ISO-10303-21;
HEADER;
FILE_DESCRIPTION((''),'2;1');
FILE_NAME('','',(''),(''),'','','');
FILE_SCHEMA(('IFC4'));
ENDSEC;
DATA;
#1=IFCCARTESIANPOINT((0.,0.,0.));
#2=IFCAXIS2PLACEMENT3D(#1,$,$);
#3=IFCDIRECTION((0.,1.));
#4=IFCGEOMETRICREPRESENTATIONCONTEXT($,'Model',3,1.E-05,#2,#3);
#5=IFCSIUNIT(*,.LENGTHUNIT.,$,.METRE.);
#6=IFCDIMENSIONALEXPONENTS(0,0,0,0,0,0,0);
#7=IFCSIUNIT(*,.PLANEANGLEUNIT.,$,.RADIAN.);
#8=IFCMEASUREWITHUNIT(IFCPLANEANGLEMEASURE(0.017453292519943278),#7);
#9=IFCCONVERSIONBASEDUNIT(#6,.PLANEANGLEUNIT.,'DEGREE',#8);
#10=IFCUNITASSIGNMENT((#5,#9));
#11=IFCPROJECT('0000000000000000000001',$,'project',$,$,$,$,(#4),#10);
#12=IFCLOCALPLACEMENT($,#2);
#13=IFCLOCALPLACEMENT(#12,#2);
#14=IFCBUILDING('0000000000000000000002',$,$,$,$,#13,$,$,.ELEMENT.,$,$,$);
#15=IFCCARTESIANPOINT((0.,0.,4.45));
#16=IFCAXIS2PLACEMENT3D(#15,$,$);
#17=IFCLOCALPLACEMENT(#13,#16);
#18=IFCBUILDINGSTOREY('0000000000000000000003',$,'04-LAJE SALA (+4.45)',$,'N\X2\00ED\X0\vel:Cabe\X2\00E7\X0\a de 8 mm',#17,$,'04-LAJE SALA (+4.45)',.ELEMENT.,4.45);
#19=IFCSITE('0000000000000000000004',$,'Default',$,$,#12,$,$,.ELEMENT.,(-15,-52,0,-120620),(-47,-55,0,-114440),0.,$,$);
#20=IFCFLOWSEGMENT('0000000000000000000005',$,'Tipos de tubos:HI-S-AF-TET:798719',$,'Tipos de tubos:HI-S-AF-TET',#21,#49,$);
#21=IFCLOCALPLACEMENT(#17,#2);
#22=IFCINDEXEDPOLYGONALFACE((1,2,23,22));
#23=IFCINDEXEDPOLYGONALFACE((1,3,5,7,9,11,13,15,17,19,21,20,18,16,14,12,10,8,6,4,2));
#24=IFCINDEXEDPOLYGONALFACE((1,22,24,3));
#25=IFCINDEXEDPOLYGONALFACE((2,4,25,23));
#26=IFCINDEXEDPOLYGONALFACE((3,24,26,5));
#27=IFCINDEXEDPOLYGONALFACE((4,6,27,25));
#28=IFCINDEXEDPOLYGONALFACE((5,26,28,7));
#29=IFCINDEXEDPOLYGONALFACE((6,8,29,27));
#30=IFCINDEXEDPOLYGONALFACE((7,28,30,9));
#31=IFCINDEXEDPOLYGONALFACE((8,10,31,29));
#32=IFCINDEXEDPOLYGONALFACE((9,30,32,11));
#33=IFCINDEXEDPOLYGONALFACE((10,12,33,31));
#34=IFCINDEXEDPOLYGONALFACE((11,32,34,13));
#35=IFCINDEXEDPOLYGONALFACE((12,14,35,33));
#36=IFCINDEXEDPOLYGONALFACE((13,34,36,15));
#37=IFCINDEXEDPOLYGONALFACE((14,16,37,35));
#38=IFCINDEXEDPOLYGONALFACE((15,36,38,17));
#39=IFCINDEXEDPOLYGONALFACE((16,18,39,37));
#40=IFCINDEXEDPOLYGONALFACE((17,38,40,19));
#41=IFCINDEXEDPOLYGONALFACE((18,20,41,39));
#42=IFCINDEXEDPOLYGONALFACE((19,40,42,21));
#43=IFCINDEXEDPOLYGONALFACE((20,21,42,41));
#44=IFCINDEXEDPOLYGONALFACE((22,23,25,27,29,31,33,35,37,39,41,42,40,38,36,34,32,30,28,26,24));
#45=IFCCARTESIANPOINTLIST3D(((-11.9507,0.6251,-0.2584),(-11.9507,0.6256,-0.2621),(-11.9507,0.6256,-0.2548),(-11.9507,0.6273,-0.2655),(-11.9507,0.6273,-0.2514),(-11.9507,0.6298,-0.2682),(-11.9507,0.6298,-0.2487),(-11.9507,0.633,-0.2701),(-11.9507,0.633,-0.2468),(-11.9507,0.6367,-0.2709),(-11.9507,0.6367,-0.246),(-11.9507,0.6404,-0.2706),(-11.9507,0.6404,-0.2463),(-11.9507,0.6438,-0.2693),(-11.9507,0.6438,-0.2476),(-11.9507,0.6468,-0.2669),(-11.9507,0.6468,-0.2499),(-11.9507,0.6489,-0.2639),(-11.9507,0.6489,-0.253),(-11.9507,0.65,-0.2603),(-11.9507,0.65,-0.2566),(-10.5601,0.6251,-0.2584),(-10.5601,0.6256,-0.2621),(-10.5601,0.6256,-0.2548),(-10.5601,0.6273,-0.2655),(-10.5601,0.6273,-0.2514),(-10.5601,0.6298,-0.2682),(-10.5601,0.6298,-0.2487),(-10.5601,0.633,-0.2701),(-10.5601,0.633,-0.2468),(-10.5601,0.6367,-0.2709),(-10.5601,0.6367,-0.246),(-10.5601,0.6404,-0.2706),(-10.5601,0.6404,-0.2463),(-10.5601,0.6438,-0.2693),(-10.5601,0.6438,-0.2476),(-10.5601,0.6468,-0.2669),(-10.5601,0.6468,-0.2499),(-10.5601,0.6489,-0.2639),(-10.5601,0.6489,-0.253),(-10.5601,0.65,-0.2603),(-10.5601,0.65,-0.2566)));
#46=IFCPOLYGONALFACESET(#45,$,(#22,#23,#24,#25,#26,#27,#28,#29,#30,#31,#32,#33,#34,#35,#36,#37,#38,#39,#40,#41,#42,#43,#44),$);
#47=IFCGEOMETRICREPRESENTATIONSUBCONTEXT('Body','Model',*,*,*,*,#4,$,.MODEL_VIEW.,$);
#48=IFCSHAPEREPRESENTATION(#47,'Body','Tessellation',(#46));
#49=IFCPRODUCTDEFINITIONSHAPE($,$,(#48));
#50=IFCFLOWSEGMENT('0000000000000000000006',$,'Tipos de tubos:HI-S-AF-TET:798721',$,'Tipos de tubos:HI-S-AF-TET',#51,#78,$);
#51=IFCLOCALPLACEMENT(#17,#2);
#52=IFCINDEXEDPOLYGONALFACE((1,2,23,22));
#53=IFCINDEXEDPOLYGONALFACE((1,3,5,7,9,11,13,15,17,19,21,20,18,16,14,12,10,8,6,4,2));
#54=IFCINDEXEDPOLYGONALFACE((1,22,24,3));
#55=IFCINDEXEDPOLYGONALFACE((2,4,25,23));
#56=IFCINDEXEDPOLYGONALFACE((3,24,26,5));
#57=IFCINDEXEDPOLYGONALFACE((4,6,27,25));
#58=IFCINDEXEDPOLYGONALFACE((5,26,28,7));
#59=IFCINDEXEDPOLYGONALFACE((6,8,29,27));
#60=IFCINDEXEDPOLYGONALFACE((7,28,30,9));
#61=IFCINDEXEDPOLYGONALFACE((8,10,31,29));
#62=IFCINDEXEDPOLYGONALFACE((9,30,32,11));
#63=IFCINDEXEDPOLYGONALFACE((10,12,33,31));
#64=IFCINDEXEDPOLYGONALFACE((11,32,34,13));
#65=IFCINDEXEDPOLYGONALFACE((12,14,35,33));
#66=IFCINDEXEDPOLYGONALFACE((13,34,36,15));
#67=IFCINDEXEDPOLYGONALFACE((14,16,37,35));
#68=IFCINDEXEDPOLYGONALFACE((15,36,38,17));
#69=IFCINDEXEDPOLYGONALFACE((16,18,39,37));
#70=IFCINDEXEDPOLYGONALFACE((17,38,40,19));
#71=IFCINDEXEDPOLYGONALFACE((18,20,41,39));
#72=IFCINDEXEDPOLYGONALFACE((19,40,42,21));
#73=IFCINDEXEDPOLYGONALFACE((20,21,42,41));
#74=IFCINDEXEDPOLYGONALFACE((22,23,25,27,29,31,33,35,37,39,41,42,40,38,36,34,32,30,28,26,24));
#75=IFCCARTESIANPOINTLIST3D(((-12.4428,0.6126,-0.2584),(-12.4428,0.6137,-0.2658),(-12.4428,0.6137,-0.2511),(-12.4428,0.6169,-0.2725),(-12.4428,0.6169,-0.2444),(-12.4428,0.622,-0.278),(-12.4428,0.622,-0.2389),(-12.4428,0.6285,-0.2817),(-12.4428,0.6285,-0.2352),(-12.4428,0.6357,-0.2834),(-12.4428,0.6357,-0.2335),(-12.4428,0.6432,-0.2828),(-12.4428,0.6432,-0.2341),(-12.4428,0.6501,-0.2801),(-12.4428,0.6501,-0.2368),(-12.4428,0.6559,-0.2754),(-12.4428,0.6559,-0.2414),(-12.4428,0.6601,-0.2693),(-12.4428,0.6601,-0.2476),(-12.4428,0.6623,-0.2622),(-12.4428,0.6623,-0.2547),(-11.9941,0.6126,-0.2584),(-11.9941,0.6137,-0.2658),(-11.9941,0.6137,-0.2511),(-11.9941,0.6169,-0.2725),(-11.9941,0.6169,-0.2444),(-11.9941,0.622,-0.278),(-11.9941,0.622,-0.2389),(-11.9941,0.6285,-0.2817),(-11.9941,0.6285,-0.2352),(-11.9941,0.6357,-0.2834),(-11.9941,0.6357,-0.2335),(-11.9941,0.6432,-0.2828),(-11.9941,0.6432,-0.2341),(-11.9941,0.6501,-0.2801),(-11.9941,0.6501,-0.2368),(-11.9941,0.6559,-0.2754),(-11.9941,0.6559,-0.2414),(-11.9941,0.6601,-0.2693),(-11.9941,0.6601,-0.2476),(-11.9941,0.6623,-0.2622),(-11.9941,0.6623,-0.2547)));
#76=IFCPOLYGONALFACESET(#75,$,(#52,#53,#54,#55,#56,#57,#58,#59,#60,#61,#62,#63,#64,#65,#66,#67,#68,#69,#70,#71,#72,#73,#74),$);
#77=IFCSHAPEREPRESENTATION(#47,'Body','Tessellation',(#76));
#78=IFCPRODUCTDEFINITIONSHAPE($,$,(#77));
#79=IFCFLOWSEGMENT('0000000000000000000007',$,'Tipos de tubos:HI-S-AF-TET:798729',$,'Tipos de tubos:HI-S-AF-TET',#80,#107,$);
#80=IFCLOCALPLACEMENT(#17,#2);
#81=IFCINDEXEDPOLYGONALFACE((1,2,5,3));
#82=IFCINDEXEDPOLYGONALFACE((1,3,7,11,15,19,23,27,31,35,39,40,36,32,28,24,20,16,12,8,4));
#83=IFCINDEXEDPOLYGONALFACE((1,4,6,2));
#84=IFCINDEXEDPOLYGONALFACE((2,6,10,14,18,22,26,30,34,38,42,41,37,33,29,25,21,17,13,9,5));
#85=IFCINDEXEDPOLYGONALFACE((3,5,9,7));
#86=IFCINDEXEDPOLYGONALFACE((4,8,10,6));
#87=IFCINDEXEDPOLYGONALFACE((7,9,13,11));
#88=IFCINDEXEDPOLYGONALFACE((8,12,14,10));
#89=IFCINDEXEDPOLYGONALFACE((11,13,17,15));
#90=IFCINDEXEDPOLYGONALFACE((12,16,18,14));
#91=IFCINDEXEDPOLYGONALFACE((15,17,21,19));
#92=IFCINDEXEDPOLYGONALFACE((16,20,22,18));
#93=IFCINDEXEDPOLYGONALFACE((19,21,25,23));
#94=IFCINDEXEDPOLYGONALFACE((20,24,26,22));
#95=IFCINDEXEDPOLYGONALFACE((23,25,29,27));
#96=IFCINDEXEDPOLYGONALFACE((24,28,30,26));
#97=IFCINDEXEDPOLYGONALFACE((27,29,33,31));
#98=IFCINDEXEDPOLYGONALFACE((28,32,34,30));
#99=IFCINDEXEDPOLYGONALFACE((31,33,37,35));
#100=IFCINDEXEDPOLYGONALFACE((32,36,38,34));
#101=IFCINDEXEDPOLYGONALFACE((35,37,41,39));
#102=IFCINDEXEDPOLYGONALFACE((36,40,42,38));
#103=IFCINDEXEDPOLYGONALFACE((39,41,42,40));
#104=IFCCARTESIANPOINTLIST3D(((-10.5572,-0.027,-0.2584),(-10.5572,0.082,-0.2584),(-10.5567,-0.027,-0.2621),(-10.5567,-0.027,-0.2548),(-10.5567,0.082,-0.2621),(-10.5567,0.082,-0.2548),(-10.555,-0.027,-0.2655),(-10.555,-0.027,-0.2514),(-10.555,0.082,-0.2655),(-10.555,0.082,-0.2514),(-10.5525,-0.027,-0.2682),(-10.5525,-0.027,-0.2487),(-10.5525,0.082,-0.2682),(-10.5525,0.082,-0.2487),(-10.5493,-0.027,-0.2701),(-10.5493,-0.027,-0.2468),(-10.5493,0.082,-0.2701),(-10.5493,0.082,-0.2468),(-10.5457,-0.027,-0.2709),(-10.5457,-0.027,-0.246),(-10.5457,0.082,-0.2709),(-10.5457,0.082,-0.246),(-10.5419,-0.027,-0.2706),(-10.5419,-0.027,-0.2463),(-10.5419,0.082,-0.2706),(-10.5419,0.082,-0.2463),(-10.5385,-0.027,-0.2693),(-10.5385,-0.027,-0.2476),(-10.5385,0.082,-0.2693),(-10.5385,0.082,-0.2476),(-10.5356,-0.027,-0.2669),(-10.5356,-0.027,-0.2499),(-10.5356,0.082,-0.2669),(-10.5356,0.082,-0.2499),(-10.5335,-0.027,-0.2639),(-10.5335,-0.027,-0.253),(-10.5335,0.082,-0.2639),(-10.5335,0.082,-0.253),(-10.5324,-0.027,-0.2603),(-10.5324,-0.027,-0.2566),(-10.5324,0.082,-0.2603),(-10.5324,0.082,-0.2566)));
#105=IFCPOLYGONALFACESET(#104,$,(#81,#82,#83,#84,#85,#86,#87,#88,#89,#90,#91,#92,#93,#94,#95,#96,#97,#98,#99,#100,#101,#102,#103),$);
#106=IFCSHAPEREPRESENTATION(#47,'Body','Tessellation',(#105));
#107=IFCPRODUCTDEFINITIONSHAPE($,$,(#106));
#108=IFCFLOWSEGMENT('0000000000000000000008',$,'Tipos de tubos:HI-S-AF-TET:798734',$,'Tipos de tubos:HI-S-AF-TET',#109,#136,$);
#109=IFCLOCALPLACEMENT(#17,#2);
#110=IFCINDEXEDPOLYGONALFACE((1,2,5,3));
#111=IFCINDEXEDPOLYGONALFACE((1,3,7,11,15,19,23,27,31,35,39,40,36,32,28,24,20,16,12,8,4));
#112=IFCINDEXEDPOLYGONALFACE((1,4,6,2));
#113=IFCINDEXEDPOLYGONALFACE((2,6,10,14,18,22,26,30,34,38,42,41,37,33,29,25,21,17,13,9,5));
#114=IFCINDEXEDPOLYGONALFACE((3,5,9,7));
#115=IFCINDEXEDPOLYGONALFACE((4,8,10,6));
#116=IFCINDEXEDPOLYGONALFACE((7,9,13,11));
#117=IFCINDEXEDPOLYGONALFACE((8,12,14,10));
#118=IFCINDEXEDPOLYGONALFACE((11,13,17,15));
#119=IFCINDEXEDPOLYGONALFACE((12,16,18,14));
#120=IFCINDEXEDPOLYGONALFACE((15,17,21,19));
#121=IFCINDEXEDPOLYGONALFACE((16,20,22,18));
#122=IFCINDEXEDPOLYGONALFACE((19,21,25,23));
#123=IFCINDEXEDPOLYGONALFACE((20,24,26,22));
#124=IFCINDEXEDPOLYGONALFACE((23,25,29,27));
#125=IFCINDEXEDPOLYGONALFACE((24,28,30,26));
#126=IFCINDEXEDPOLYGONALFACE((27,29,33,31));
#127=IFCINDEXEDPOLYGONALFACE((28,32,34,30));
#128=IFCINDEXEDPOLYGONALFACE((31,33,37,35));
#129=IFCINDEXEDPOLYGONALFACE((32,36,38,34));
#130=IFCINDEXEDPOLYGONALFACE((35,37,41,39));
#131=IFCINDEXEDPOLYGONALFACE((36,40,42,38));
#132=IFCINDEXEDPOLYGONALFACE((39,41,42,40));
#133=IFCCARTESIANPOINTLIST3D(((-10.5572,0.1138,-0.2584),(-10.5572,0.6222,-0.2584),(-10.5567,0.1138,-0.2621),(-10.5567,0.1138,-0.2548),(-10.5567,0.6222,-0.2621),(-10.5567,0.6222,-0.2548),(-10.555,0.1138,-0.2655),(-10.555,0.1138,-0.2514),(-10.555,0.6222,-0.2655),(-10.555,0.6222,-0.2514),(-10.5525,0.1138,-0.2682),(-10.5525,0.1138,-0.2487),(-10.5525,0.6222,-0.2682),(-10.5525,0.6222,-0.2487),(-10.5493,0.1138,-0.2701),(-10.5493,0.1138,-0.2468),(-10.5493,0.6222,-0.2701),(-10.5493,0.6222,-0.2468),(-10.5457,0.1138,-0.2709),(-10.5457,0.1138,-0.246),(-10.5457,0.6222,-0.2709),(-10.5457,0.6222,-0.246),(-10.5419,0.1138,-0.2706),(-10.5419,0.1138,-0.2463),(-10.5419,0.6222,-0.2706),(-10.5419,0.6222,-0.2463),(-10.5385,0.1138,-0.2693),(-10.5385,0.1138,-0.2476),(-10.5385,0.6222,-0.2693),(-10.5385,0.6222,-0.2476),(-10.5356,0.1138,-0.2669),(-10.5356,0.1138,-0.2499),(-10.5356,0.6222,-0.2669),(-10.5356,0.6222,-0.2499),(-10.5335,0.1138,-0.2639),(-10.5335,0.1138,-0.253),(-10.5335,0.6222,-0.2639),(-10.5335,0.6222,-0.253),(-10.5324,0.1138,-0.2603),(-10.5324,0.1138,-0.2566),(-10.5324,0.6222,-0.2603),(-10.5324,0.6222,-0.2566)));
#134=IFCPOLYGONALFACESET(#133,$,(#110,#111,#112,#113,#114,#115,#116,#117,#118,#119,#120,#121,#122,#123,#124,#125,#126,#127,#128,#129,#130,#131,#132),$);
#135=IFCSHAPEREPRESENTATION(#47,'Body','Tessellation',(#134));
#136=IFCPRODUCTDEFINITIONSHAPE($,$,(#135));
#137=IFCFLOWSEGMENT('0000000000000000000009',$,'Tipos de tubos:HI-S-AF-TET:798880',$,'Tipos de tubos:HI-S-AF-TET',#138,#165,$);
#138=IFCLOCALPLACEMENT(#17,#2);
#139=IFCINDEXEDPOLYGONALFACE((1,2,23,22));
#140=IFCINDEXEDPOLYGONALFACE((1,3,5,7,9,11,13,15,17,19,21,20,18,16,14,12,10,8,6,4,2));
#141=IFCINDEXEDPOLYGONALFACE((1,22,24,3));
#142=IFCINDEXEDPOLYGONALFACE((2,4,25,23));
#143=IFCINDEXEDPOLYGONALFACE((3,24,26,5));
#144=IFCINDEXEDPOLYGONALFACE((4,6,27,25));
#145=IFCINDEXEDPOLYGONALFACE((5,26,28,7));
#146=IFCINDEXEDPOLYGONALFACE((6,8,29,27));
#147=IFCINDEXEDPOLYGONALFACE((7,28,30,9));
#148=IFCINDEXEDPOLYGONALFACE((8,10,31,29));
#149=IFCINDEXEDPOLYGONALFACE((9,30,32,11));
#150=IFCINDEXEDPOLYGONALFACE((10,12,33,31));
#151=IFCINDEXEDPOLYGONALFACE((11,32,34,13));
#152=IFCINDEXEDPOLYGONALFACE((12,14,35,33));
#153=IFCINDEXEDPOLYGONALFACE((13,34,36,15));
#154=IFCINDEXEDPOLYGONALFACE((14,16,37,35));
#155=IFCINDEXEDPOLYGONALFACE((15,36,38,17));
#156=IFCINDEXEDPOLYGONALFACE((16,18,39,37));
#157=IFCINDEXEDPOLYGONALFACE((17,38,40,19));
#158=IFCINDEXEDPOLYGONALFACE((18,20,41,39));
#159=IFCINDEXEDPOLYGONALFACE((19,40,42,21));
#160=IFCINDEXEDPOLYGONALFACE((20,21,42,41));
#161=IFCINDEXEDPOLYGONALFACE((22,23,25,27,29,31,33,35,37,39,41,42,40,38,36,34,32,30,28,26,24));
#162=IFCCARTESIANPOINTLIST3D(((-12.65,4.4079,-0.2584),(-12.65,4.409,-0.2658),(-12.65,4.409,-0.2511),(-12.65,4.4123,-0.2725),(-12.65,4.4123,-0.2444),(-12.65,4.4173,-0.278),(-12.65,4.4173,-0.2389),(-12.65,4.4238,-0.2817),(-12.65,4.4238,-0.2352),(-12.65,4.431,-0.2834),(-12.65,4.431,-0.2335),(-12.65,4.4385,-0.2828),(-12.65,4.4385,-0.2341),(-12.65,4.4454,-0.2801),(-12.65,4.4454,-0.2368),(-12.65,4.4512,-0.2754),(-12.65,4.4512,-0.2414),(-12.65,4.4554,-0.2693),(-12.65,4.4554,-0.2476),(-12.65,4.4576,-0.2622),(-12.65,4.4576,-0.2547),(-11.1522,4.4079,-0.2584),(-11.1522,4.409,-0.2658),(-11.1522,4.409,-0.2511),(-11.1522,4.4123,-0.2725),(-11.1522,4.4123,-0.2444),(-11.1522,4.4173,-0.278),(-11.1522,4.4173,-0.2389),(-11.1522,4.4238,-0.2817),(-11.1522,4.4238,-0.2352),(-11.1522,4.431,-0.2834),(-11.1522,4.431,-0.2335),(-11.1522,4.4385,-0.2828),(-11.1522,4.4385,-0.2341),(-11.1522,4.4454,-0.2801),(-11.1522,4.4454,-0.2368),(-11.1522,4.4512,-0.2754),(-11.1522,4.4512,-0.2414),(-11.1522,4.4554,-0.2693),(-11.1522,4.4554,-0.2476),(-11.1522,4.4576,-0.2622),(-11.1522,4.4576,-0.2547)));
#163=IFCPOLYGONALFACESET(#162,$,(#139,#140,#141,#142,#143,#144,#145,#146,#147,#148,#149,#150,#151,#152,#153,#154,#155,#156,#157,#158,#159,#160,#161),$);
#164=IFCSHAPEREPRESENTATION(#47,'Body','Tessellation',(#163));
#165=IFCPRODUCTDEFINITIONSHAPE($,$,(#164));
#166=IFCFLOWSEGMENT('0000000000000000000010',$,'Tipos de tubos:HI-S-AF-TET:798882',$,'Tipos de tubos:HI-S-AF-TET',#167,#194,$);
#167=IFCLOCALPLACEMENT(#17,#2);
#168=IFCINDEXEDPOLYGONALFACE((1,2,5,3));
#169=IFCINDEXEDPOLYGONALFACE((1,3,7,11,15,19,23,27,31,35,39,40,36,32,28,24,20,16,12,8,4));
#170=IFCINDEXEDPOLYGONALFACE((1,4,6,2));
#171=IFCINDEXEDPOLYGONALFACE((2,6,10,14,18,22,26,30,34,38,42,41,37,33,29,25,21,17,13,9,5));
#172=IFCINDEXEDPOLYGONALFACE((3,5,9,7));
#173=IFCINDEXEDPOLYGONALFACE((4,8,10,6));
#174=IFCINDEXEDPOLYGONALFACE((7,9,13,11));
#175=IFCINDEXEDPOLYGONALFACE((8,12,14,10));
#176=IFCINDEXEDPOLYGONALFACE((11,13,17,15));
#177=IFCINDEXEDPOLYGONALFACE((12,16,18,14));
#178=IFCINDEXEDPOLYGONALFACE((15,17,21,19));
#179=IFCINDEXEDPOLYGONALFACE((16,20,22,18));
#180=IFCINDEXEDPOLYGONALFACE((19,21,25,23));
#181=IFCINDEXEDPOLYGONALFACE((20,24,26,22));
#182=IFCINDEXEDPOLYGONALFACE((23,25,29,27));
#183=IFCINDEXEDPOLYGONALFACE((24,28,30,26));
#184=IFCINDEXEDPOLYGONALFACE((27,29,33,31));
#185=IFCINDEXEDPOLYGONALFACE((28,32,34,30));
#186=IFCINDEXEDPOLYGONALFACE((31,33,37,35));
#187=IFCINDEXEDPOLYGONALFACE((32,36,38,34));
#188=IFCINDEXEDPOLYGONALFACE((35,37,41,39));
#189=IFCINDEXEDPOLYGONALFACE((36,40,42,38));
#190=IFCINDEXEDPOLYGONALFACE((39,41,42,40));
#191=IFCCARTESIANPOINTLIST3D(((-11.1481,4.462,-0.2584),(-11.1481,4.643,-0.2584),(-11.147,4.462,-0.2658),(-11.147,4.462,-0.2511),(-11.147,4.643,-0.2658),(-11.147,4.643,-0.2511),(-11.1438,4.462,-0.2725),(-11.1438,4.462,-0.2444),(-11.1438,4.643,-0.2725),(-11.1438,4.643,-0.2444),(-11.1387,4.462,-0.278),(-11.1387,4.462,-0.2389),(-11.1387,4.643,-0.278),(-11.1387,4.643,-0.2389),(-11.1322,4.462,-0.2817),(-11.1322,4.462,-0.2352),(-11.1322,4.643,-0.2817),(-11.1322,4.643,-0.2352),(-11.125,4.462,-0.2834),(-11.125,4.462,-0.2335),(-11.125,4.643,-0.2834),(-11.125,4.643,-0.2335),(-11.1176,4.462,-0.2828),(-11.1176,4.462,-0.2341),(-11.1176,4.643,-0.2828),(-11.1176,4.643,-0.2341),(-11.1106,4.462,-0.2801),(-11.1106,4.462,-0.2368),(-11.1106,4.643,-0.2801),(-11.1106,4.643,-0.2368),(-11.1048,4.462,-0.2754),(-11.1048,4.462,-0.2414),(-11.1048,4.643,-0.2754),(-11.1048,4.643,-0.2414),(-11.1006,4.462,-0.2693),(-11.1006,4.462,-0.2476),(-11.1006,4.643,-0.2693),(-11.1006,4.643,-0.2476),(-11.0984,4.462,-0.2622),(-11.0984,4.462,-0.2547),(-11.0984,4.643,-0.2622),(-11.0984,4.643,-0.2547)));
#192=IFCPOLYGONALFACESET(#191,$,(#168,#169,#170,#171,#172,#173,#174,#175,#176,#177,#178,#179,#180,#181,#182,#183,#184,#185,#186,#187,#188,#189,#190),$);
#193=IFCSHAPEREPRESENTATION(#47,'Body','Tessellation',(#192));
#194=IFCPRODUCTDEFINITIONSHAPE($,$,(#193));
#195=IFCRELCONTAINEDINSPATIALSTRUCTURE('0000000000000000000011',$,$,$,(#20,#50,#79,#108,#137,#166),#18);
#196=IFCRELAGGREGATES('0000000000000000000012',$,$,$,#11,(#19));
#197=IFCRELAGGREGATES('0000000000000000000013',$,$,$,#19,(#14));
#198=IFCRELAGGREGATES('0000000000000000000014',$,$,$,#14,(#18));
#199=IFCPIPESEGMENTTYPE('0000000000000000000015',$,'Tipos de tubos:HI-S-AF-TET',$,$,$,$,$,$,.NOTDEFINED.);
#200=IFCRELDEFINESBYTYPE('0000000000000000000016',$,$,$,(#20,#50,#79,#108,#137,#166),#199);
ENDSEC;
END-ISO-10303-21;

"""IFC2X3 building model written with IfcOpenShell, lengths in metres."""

from ifc_helpers import new_model, entity, si_unit, converted_unit, direction, frame, frame_2d, origin, origin_2d_with_axis, place, context, subcontext, project, spatial, circle, extrude, type_object, element, save


model = new_model("IFC2X3")

# Units and contexts
model_context = context("Model", 3, precision=1e-05, world=origin(), true_north=direction((0.0, 1.0)))
body_context = subcontext(model_context, "Body", "Model", "MODEL_VIEW")
ifc_project = project(units=[si_unit("LENGTHUNIT", "METRE"), converted_unit("PLANEANGLEUNIT", "DEGREE", entity("IfcPlaneAngleMeasure", 0.017453292519943278), si_unit("PLANEANGLEUNIT", "RADIAN"), dimensions=[0, 0, 0, 0, 0, 0, 0])], contexts=[model_context])

# Site, building, storey
site_placement = place(None, origin())
site = spatial("IfcSite", under=ifc_project, at=site_placement, Name="Default", CompositionType="ELEMENT", RefLatitude=(-15, -52, 0, -120620), RefLongitude=(-47, -55, 0, -114440), RefElevation=0.0)
building_placement = place(site_placement, origin())
building = spatial("IfcBuilding", under=site, at=building_placement, CompositionType="ELEMENT")
storey_placement = place(building_placement, frame((0.0, 0.0, 4.45)))
storey = spatial("IfcBuildingStorey", under=building, at=storey_placement, Name="04-LAJE SALA (+4.45)", ObjectType="Nível:Cabeça de 8 mm", LongName="04-LAJE SALA (+4.45)", CompositionType="ELEMENT", Elevation=4.45)

# Flow segments
pipe_segment_type_1 = type_object("IfcPipeSegmentType", Name="Tipos de tubos:HI-S-AF-TET", PredefinedType="NOTDEFINED")
flow_segment_1_placement = place(storey_placement, origin())
element("IfcFlowSegment", 1, at=flow_segment_1_placement, inside=storey, type_object=pipe_segment_type_1, Name="Tipos de tubos:HI-S-AF-TET:798719", ObjectType="Tipos de tubos:HI-S-AF-TET", context=body_context, shape_type="SweptSolid", body=[
    extrude(circle(Radius=0.0125, at=frame_2d((0.0, 0.0), x_axis=(1.0, 0.0))), frame((-11.9507, 0.6376, -0.2584), z_axis=(1.0, 0.0, 0.0), x_axis=(0.0, -1.0, 0.0)), (0.0, 0.0, 1.0), 1.3906),
])
flow_segment_2_placement = place(storey_placement, origin())
element("IfcFlowSegment", 2, at=flow_segment_2_placement, inside=storey, type_object=pipe_segment_type_1, Name="Tipos de tubos:HI-S-AF-TET:798721", ObjectType="Tipos de tubos:HI-S-AF-TET", context=body_context, shape_type="SweptSolid", body=[
    extrude(circle(Radius=0.025, at=frame_2d((0.0, 0.0), x_axis=(1.0, 0.0))), frame((-12.4428, 0.6376, -0.2584), z_axis=(1.0, 0.0, 0.0), x_axis=(0.0, -1.0, 0.0)), (0.0, 0.0, 1.0), 0.4486),
])
flow_segment_3_placement = place(storey_placement, origin())
element("IfcFlowSegment", 3, at=flow_segment_3_placement, inside=storey, type_object=pipe_segment_type_1, Name="Tipos de tubos:HI-S-AF-TET:798729", ObjectType="Tipos de tubos:HI-S-AF-TET", context=body_context, shape_type="SweptSolid", body=[
    extrude(circle(Radius=0.0125, at=origin_2d_with_axis()), frame((-10.5447, -0.027, -0.2584), z_axis=(0.0, 1.0, 0.0), x_axis=(-1.0, 0.0, 0.0)), (0.0, 0.0, 1.0), 0.109),
])
flow_segment_4_placement = place(storey_placement, origin())
element("IfcFlowSegment", 4, at=flow_segment_4_placement, inside=storey, type_object=pipe_segment_type_1, Name="Tipos de tubos:HI-S-AF-TET:798734", ObjectType="Tipos de tubos:HI-S-AF-TET", context=body_context, shape_type="SweptSolid", body=[
    extrude(circle(Radius=0.0125, at=origin_2d_with_axis()), frame((-10.5447, 0.1138, -0.2584), z_axis=(0.0, 1.0, 0.0), x_axis=(-1.0, 0.0, 0.0)), (0.0, 0.0, 1.0), 0.5084),
])
flow_segment_5_placement = place(storey_placement, origin())
element("IfcFlowSegment", 5, at=flow_segment_5_placement, inside=storey, type_object=pipe_segment_type_1, Name="Tipos de tubos:HI-S-AF-TET:798880", ObjectType="Tipos de tubos:HI-S-AF-TET", context=body_context, shape_type="SweptSolid", body=[
    extrude(circle(Radius=0.025, at=origin_2d_with_axis()), frame((-12.65, 4.4329, -0.2584), z_axis=(1.0, 0.0, 0.0), x_axis=(0.0, -1.0, 0.0)), (0.0, 0.0, 1.0), 1.4978),
])
flow_segment_6_placement = place(storey_placement, origin())
element("IfcFlowSegment", 6, at=flow_segment_6_placement, inside=storey, type_object=pipe_segment_type_1, Name="Tipos de tubos:HI-S-AF-TET:798882", ObjectType="Tipos de tubos:HI-S-AF-TET", context=body_context, shape_type="SweptSolid", body=[
    extrude(circle(Radius=0.025, at=frame_2d((0.0, 0.0), x_axis=(1.0, 0.0))), frame((-11.1231, 4.462, -0.2584), z_axis=(0.0, 1.0, 0.0), x_axis=(-1.0, 0.0, 0.0)), (0.0, 0.0, 1.0), 0.181),
])

save(model, "model.ifc")
